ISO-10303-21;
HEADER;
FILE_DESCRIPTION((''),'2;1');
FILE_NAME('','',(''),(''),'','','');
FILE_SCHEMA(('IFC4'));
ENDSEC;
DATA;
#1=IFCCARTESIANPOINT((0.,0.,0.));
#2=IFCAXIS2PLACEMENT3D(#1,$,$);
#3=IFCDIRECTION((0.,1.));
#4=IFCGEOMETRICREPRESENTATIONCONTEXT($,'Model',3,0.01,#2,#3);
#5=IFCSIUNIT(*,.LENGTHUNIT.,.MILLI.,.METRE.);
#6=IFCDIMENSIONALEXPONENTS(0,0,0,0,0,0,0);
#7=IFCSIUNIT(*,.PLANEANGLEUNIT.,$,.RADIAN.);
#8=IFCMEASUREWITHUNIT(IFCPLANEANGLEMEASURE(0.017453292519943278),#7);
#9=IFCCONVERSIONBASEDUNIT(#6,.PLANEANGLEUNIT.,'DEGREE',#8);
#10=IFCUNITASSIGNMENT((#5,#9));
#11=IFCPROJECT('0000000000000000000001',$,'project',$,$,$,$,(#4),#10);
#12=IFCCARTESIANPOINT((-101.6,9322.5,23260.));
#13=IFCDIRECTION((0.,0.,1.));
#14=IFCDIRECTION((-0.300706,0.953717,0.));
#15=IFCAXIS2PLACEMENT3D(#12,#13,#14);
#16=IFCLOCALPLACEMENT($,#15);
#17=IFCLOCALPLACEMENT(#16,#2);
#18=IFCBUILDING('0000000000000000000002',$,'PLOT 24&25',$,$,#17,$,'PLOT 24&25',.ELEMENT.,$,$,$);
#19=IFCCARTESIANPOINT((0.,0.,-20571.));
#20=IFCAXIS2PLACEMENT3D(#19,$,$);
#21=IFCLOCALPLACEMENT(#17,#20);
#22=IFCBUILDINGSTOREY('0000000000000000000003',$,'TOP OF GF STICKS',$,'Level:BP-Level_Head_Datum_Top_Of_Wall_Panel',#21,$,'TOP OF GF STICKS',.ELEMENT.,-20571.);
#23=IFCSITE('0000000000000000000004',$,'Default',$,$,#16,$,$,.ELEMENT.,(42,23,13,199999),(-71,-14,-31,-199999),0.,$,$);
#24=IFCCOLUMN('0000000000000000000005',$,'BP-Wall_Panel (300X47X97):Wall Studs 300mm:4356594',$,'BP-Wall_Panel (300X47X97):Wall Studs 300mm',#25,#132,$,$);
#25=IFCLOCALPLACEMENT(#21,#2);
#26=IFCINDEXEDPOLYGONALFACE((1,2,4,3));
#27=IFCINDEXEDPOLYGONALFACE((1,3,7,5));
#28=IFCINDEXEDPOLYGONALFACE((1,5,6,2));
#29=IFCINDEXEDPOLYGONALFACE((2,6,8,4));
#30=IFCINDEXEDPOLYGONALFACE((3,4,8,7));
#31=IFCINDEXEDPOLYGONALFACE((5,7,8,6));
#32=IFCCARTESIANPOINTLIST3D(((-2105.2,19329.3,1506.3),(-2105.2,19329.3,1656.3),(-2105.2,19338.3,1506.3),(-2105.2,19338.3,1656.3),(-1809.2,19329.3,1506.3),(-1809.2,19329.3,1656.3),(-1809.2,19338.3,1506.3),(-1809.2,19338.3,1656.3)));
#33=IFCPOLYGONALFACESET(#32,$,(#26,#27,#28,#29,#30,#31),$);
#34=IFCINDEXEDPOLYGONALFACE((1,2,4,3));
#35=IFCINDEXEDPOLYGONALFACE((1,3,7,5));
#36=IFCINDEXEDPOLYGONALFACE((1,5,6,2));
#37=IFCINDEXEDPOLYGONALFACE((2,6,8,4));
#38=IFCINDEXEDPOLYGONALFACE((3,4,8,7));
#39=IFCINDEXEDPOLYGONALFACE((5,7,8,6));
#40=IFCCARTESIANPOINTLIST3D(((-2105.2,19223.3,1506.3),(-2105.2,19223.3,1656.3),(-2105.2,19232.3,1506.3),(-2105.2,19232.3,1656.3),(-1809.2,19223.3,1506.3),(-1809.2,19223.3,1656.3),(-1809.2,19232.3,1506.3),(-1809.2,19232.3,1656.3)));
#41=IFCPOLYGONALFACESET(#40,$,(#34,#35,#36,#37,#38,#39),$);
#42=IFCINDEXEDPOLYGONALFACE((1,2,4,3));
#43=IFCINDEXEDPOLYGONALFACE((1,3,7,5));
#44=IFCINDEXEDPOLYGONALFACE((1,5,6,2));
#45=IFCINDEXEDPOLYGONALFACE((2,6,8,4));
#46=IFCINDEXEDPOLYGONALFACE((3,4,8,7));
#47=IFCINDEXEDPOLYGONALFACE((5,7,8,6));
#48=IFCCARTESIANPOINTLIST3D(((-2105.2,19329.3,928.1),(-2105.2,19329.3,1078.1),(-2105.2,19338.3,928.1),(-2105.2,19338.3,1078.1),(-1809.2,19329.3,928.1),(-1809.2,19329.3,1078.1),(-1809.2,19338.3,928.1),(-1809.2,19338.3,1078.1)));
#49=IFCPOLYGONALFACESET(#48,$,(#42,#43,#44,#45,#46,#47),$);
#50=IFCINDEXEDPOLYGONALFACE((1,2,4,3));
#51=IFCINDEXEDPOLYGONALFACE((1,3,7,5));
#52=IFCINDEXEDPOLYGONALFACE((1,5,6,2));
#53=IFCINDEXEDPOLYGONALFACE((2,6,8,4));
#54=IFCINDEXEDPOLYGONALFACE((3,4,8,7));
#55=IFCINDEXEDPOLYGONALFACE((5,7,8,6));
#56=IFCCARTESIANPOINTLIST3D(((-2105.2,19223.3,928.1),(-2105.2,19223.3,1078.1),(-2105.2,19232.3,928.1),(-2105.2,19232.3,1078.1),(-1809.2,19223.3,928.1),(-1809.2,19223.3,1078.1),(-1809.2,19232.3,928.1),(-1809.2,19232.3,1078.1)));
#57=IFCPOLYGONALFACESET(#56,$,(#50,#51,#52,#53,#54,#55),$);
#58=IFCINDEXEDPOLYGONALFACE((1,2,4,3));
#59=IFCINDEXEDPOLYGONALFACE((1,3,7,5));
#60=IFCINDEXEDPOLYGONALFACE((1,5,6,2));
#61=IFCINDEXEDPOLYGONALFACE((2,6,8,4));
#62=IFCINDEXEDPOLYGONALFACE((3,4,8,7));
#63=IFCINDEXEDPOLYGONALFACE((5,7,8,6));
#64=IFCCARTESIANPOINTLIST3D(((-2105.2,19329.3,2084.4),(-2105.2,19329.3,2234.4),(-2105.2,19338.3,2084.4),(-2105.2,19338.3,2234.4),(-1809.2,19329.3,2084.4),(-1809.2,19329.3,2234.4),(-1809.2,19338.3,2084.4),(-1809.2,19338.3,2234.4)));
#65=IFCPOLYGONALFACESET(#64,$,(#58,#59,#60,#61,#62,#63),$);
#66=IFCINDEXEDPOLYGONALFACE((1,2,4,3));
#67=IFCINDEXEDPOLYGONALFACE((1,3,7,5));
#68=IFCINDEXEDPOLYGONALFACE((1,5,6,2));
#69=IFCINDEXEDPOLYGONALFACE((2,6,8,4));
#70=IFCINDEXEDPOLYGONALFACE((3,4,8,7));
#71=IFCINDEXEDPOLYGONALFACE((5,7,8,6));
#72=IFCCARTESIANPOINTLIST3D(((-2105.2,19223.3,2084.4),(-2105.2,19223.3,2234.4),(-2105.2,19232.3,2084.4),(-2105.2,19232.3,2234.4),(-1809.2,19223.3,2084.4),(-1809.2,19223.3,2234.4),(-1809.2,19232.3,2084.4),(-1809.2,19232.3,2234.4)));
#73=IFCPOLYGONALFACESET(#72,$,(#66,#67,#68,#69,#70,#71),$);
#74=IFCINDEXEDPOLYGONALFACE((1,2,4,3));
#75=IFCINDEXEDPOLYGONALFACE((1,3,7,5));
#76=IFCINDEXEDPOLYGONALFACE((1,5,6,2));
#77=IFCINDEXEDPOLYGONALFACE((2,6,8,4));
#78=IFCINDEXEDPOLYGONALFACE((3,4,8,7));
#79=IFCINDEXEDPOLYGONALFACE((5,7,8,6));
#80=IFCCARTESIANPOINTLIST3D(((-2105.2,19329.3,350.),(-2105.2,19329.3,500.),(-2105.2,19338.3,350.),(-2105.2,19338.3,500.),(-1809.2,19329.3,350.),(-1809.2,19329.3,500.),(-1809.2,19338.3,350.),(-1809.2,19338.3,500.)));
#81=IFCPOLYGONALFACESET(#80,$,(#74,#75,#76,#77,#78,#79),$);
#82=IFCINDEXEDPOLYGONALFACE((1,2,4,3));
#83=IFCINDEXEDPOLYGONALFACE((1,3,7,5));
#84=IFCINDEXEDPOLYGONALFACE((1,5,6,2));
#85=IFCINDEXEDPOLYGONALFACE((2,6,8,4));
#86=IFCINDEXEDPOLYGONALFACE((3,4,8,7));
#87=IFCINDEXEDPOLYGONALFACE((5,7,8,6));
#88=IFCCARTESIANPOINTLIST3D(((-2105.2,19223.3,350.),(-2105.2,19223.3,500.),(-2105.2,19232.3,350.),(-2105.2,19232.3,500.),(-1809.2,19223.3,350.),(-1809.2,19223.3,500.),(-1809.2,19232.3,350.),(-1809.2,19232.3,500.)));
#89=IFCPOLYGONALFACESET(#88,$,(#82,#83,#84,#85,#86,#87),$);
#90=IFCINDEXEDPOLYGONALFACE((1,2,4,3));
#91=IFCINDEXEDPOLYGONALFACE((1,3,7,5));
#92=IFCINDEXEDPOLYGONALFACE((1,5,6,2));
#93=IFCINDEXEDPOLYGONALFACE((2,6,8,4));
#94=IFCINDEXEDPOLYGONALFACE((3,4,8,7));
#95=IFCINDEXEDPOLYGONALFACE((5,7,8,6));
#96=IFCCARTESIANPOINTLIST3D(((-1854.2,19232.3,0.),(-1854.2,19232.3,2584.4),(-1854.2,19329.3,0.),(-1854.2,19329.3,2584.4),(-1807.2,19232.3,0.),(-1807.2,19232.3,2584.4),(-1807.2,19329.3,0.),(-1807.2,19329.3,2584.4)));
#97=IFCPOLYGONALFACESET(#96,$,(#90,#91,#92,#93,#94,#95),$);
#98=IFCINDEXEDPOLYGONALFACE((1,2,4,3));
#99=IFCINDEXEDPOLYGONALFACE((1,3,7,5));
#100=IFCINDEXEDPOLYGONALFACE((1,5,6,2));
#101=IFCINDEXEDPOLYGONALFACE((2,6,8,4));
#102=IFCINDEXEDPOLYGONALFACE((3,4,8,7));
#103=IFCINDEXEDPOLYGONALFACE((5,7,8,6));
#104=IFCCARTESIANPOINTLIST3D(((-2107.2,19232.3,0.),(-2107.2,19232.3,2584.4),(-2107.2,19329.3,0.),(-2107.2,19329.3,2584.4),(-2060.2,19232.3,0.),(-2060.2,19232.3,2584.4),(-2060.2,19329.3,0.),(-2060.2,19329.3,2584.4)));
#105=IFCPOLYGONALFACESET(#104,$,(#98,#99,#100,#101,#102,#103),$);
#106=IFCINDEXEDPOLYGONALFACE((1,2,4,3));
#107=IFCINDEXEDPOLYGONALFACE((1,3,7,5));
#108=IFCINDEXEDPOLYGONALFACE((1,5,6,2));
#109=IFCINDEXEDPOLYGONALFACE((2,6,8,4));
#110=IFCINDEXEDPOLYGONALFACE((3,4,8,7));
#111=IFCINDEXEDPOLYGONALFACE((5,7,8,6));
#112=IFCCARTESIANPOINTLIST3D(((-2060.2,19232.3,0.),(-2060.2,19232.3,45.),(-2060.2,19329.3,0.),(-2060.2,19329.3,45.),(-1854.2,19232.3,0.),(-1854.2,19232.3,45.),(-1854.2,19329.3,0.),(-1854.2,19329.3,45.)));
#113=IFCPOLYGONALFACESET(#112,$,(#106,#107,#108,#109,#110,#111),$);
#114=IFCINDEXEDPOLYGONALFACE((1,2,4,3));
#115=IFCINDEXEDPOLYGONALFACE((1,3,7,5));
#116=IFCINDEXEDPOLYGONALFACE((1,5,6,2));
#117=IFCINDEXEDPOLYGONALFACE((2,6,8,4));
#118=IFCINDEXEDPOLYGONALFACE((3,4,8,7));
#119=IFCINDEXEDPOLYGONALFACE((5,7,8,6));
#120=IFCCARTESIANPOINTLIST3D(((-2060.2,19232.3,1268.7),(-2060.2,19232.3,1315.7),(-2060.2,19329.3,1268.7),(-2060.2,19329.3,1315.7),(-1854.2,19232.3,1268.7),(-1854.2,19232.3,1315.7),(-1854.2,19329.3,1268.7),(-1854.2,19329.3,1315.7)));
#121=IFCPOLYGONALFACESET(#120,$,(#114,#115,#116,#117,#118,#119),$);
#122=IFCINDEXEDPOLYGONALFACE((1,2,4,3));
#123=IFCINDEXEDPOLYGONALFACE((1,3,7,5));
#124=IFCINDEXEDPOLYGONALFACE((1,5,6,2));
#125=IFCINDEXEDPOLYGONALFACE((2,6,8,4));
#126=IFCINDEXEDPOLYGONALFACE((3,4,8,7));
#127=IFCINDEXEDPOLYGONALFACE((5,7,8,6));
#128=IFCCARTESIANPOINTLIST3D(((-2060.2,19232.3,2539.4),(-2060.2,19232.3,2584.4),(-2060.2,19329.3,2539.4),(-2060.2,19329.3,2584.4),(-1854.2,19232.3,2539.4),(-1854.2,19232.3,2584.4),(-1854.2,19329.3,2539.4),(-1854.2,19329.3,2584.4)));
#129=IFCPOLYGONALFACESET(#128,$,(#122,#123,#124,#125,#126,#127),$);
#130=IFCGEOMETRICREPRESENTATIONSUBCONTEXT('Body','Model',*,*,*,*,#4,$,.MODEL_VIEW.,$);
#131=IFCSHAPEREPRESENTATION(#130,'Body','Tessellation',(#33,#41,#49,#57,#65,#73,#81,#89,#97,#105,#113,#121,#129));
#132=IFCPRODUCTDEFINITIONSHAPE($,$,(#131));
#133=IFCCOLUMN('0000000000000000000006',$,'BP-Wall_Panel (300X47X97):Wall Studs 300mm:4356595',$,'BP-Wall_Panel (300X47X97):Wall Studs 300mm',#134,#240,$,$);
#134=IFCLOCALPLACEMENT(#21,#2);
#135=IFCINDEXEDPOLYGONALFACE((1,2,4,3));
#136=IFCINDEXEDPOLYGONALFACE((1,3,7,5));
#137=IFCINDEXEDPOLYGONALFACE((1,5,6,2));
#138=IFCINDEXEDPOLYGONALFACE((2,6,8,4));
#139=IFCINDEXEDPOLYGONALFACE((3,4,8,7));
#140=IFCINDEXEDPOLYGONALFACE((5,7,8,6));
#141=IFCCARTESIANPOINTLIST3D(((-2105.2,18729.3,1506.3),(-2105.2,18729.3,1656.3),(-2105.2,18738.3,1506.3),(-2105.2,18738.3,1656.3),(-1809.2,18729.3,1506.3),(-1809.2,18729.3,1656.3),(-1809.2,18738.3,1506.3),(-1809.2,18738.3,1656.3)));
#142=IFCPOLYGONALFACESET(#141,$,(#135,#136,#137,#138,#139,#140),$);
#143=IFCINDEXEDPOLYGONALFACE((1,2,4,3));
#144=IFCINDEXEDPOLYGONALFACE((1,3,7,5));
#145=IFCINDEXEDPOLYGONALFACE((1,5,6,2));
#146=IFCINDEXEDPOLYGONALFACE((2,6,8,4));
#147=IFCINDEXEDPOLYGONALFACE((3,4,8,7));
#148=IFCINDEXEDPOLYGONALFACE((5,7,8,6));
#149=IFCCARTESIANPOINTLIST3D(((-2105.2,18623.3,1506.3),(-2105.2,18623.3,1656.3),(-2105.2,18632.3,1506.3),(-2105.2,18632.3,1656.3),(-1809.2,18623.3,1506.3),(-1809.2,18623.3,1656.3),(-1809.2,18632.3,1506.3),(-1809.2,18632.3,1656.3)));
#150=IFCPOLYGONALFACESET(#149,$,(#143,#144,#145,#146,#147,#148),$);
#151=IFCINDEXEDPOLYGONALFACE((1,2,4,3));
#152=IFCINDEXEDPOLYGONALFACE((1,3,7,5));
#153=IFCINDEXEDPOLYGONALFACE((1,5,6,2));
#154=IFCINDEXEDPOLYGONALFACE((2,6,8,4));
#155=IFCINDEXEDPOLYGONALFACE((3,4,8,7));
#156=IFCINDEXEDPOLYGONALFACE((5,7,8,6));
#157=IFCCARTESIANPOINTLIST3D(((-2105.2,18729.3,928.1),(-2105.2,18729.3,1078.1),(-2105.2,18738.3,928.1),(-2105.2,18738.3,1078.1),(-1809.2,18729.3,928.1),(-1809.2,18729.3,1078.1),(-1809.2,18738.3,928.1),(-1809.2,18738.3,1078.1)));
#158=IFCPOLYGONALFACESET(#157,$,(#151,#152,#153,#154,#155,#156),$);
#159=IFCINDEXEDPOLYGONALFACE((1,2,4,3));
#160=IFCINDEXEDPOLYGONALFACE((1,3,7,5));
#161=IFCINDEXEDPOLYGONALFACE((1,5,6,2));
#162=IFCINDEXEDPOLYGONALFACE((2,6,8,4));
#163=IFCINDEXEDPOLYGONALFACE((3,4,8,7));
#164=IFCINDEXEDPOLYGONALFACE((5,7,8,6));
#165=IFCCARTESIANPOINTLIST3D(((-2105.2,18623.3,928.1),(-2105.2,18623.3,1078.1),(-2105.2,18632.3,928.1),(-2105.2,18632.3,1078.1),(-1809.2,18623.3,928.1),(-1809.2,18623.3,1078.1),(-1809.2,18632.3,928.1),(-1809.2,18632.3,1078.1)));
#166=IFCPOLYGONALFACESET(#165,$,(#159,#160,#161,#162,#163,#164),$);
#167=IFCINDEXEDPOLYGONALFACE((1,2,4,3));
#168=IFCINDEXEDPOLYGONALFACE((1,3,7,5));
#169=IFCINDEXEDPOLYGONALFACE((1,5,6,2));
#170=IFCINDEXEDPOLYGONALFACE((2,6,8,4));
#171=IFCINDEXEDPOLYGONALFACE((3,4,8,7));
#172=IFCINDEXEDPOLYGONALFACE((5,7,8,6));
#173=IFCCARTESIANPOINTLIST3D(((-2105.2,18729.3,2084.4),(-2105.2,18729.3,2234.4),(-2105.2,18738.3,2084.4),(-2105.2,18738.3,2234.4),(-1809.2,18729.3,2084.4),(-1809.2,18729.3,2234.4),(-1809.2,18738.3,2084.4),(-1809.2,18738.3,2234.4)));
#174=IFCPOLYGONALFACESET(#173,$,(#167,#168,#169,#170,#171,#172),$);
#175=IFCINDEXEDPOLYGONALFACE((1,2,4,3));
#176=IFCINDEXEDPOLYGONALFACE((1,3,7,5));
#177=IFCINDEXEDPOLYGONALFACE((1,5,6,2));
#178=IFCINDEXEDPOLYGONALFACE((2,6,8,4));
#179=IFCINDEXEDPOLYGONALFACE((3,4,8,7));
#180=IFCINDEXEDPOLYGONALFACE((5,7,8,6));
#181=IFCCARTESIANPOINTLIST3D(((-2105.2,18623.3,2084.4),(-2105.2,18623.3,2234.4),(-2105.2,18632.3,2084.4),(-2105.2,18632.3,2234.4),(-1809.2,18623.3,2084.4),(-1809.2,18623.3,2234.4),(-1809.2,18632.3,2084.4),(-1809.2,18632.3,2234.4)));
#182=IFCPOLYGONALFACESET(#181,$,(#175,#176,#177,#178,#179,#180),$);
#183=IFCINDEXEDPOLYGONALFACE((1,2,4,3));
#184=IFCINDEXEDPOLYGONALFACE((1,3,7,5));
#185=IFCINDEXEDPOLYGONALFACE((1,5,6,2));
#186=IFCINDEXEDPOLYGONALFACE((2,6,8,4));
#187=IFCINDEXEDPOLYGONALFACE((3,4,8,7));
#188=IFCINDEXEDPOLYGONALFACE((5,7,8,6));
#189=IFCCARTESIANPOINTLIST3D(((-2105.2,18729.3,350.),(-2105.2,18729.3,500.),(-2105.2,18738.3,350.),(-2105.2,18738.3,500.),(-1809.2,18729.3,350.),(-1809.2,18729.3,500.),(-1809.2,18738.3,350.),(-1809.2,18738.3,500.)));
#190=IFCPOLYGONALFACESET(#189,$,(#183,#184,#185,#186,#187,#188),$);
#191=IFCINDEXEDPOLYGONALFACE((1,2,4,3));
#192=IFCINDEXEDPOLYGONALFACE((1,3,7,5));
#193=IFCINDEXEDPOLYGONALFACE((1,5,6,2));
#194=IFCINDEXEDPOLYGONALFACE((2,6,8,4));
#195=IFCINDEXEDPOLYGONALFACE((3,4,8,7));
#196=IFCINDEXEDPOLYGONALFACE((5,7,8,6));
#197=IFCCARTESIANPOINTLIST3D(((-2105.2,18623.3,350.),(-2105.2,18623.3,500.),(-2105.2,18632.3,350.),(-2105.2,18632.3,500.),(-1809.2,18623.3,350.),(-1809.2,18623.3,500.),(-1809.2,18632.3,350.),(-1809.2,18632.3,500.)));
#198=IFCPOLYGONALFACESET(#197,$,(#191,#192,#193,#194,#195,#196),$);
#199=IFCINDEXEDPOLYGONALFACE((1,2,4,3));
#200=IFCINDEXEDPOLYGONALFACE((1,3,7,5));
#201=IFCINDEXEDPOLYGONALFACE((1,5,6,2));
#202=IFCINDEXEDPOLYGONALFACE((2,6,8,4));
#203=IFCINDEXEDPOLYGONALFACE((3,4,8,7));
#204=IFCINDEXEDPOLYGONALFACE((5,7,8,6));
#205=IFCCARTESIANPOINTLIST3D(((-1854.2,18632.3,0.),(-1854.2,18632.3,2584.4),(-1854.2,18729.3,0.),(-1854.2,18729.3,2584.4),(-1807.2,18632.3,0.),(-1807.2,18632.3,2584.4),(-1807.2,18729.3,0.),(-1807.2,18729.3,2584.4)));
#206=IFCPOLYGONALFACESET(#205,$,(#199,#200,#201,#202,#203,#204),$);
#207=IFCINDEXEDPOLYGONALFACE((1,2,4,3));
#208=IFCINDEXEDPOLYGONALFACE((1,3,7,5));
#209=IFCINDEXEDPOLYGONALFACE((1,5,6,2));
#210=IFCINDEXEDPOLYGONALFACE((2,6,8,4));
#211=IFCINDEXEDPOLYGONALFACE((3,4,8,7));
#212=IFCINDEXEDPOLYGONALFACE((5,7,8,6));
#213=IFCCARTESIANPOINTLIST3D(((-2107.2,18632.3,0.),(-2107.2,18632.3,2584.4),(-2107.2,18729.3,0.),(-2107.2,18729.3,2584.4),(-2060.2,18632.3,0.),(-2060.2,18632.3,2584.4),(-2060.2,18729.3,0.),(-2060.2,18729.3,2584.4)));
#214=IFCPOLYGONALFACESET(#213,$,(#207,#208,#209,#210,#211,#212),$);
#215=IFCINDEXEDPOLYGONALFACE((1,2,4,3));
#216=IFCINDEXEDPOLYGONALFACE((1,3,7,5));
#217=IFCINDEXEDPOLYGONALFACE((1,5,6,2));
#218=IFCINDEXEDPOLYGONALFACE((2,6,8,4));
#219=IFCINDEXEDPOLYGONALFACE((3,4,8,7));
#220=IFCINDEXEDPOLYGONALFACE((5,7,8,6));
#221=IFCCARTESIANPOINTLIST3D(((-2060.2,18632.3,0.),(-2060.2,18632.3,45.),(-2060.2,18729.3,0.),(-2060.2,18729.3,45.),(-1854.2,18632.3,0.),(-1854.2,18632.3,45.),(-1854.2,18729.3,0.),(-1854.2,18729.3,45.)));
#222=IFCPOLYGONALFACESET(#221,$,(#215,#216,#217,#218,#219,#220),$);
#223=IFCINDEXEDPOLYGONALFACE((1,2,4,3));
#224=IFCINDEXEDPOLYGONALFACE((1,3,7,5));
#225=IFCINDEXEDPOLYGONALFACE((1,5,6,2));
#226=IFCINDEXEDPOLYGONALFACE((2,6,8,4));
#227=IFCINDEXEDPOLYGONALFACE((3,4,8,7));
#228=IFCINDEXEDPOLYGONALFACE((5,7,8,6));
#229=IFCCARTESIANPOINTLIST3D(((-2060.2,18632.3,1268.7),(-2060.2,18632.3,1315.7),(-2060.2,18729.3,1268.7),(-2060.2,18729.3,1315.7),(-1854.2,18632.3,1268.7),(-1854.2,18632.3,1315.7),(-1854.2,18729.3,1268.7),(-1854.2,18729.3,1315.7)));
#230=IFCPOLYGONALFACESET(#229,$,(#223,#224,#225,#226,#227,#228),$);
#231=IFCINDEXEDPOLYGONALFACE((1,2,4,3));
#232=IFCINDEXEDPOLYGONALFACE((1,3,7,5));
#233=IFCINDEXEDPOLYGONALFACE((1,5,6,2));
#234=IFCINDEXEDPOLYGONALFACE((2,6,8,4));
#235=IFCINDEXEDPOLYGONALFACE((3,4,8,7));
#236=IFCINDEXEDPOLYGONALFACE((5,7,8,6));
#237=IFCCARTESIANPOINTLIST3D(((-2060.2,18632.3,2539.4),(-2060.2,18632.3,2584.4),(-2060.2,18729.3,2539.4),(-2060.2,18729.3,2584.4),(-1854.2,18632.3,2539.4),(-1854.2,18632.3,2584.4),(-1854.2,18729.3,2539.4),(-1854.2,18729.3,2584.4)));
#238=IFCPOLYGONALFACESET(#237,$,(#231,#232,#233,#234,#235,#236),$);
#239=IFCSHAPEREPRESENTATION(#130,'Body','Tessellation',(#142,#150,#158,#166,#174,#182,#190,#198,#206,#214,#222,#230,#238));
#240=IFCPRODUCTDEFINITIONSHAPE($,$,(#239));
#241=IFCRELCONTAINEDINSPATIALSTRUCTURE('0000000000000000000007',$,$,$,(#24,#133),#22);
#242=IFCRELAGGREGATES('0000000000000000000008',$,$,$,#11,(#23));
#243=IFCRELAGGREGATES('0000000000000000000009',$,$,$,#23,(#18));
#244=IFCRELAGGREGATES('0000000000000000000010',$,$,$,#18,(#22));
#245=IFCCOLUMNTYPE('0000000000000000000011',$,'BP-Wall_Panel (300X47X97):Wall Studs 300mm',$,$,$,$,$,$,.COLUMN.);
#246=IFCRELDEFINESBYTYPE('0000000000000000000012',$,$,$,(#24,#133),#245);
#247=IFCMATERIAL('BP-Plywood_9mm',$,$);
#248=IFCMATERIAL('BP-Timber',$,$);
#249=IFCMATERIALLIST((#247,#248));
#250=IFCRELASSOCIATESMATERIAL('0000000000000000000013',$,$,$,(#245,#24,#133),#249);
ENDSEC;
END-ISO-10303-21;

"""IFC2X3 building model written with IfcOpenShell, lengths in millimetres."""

from ifc_helpers import new_model, entity, si_unit, converted_unit, direction, frame, frame_2d, origin, origin_2d_with_axis, place, context, subcontext, project, spatial, rectangle, extrude, source, transform, mapped, material, material_list, type_object, type_shapes, element, save


model = new_model("IFC2X3")

# Units and contexts
model_context = context("Model", 3, precision=0.01, world=origin(), true_north=direction((0.0, 1.0)))
body_context = subcontext(model_context, "Body", "Model", "MODEL_VIEW")
ifc_project = project(units=[si_unit("LENGTHUNIT", "METRE", prefix="MILLI"), converted_unit("PLANEANGLEUNIT", "DEGREE", entity("IfcPlaneAngleMeasure", 0.017453292519943278), si_unit("PLANEANGLEUNIT", "RADIAN"), dimensions=[0, 0, 0, 0, 0, 0, 0])], contexts=[model_context])

# Site, building, storey
site_placement = place(None, frame((-101.6, 9322.5, 23260.0), z_axis=(0.0, 0.0, 1.0), x_axis=(-0.300706, 0.953717, 0.0)))
site = spatial("IfcSite", under=ifc_project, at=site_placement, Name="Default", CompositionType="ELEMENT", RefLatitude=(42, 23, 13, 199999), RefLongitude=(-71, -14, -31, -199999), RefElevation=0.0)
building_placement = place(site_placement, origin())
building = spatial("IfcBuilding", under=site, at=building_placement, Name="PLOT 24&25", LongName="PLOT 24&25", CompositionType="ELEMENT")
storey_placement = place(building_placement, frame((0.0, 0.0, -20571.0)))
storey = spatial("IfcBuildingStorey", under=building, at=storey_placement, Name="TOP OF GF STICKS", ObjectType="Level:BP-Level_Head_Datum_Top_Of_Wall_Panel", LongName="TOP OF GF STICKS", CompositionType="ELEMENT", Elevation=-20571.0)

# Columns
ifc_material_1 = material(Name="BP-Plywood_9mm")
ifc_material_2 = material(Name="BP-Timber")
ifc_material_list = material_list([ifc_material_1, ifc_material_2])
column_type_1 = type_object("IfcColumnType", Name="BP-Wall_Panel (300X47X97):Wall Studs 300mm", PredefinedType="COLUMN", material=ifc_material_list)
shared_shape_1 = source(origin(), body_context, "Body", "SweptSolid", [
    extrude(rectangle(XDim=296.0, YDim=9.0, at=origin_2d_with_axis()), frame((53.0, 0.0, -19064.7), z_axis=(0.0, 0.0, 1.0), x_axis=(0.0, -1.0, 0.0)), (0.0, 0.0, 1.0), 150.0),
    extrude(rectangle(XDim=9.0, YDim=296.0, at=origin_2d_with_axis()), frame((-53.0, 0.0, -19064.7), z_axis=(0.0, 0.0, 1.0), x_axis=(-1.0, 0.0, 0.0)), (0.0, 0.0, 1.0), 150.0),
    extrude(rectangle(XDim=296.0, YDim=9.0, at=origin_2d_with_axis()), frame((53.0, 0.0, -19642.9), z_axis=(0.0, 0.0, 1.0), x_axis=(0.0, -1.0, 0.0)), (0.0, 0.0, 1.0), 150.0),
    extrude(rectangle(XDim=9.0, YDim=296.0, at=origin_2d_with_axis()), frame((-53.0, 0.0, -19642.9), z_axis=(0.0, 0.0, 1.0), x_axis=(-1.0, 0.0, 0.0)), (0.0, 0.0, 1.0), 150.0),
    extrude(rectangle(XDim=296.0, YDim=9.0, at=origin_2d_with_axis()), frame((53.0, 0.0, -18486.6), z_axis=(0.0, 0.0, 1.0), x_axis=(0.0, -1.0, 0.0)), (0.0, 0.0, 1.0), 150.0),
    extrude(rectangle(XDim=9.0, YDim=296.0, at=origin_2d_with_axis()), frame((-53.0, 0.0, -18486.6), z_axis=(0.0, 0.0, 1.0), x_axis=(-1.0, 0.0, 0.0)), (0.0, 0.0, 1.0), 150.0),
    extrude(rectangle(XDim=296.0, YDim=9.0, at=origin_2d_with_axis()), frame((53.0, 0.0, -20221.0), z_axis=(0.0, 0.0, 1.0), x_axis=(0.0, -1.0, 0.0)), (0.0, 0.0, 1.0), 150.0),
    extrude(rectangle(XDim=9.0, YDim=296.0, at=origin_2d_with_axis()), frame((-53.0, 0.0, -20221.0), z_axis=(0.0, 0.0, 1.0), x_axis=(-1.0, 0.0, 0.0)), (0.0, 0.0, 1.0), 150.0),
    extrude(rectangle(XDim=97.0, YDim=47.0, at=origin_2d_with_axis()), frame((0.0, -126.5, -20571.0), z_axis=(0.0, 0.0, 1.0), x_axis=(-1.0, 0.0, 0.0)), (0.0, 0.0, 1.0), 2584.4),
    extrude(rectangle(XDim=97.0, YDim=47.0, at=frame_2d((0.0, 0.0), x_axis=(1.0, 0.0))), frame((0.0, 126.5, -20571.0), z_axis=(0.0, 0.0, 1.0), x_axis=(-1.0, 0.0, 0.0)), (0.0, 0.0, 1.0), 2584.4),
    extrude(rectangle(XDim=206.0, YDim=97.0, at=origin_2d_with_axis()), frame((0.0, 0.0, -20571.0), z_axis=(0.0, 0.0, 1.0), x_axis=(0.0, -1.0, 0.0)), (0.0, 0.0, 1.0), 45.0),
    extrude(rectangle(XDim=206.0, YDim=97.0, at=origin_2d_with_axis()), frame((0.0, 0.0, -19302.3), z_axis=(0.0, 0.0, 1.0), x_axis=(0.0, -1.0, 0.0)), (0.0, 0.0, 1.0), 47.0),
    extrude(rectangle(XDim=206.0, YDim=97.0, at=origin_2d_with_axis()), frame((0.0, 0.0, -18031.6), z_axis=(0.0, 0.0, 1.0), x_axis=(0.0, -1.0, 0.0)), (0.0, 0.0, 1.0), 45.0),
])
type_shapes(column_type_1, [shared_shape_1])
for number, where, z_axis, x_axis, name in (
    (1, (-1957.2, 19280.8, 20571.0), (0.0, 0.0, 1.0), (0.0, 1.0, 0.0), "BP-Wall_Panel (300X47X97):Wall Studs 300mm:4356594"),
    (2, (-1957.2, 18680.8, 20571.0), (0.0, 0.0, 1.0), (0.0, 1.0, 0.0), "BP-Wall_Panel (300X47X97):Wall Studs 300mm:4356595"),
):
    element("IfcColumn", number, at=place(storey_placement, frame(where, z_axis=z_axis, x_axis=x_axis)), inside=storey, type_object=column_type_1, material=ifc_material_list, Name=name, ObjectType="BP-Wall_Panel (300X47X97):Wall Studs 300mm", context=body_context, shape_type="MappedRepresentation", body=[
        mapped(shared_shape_1, transform((0.0, 0.0, 0.0), scale=1.0)),
    ])

save(model, "model.ifc")
